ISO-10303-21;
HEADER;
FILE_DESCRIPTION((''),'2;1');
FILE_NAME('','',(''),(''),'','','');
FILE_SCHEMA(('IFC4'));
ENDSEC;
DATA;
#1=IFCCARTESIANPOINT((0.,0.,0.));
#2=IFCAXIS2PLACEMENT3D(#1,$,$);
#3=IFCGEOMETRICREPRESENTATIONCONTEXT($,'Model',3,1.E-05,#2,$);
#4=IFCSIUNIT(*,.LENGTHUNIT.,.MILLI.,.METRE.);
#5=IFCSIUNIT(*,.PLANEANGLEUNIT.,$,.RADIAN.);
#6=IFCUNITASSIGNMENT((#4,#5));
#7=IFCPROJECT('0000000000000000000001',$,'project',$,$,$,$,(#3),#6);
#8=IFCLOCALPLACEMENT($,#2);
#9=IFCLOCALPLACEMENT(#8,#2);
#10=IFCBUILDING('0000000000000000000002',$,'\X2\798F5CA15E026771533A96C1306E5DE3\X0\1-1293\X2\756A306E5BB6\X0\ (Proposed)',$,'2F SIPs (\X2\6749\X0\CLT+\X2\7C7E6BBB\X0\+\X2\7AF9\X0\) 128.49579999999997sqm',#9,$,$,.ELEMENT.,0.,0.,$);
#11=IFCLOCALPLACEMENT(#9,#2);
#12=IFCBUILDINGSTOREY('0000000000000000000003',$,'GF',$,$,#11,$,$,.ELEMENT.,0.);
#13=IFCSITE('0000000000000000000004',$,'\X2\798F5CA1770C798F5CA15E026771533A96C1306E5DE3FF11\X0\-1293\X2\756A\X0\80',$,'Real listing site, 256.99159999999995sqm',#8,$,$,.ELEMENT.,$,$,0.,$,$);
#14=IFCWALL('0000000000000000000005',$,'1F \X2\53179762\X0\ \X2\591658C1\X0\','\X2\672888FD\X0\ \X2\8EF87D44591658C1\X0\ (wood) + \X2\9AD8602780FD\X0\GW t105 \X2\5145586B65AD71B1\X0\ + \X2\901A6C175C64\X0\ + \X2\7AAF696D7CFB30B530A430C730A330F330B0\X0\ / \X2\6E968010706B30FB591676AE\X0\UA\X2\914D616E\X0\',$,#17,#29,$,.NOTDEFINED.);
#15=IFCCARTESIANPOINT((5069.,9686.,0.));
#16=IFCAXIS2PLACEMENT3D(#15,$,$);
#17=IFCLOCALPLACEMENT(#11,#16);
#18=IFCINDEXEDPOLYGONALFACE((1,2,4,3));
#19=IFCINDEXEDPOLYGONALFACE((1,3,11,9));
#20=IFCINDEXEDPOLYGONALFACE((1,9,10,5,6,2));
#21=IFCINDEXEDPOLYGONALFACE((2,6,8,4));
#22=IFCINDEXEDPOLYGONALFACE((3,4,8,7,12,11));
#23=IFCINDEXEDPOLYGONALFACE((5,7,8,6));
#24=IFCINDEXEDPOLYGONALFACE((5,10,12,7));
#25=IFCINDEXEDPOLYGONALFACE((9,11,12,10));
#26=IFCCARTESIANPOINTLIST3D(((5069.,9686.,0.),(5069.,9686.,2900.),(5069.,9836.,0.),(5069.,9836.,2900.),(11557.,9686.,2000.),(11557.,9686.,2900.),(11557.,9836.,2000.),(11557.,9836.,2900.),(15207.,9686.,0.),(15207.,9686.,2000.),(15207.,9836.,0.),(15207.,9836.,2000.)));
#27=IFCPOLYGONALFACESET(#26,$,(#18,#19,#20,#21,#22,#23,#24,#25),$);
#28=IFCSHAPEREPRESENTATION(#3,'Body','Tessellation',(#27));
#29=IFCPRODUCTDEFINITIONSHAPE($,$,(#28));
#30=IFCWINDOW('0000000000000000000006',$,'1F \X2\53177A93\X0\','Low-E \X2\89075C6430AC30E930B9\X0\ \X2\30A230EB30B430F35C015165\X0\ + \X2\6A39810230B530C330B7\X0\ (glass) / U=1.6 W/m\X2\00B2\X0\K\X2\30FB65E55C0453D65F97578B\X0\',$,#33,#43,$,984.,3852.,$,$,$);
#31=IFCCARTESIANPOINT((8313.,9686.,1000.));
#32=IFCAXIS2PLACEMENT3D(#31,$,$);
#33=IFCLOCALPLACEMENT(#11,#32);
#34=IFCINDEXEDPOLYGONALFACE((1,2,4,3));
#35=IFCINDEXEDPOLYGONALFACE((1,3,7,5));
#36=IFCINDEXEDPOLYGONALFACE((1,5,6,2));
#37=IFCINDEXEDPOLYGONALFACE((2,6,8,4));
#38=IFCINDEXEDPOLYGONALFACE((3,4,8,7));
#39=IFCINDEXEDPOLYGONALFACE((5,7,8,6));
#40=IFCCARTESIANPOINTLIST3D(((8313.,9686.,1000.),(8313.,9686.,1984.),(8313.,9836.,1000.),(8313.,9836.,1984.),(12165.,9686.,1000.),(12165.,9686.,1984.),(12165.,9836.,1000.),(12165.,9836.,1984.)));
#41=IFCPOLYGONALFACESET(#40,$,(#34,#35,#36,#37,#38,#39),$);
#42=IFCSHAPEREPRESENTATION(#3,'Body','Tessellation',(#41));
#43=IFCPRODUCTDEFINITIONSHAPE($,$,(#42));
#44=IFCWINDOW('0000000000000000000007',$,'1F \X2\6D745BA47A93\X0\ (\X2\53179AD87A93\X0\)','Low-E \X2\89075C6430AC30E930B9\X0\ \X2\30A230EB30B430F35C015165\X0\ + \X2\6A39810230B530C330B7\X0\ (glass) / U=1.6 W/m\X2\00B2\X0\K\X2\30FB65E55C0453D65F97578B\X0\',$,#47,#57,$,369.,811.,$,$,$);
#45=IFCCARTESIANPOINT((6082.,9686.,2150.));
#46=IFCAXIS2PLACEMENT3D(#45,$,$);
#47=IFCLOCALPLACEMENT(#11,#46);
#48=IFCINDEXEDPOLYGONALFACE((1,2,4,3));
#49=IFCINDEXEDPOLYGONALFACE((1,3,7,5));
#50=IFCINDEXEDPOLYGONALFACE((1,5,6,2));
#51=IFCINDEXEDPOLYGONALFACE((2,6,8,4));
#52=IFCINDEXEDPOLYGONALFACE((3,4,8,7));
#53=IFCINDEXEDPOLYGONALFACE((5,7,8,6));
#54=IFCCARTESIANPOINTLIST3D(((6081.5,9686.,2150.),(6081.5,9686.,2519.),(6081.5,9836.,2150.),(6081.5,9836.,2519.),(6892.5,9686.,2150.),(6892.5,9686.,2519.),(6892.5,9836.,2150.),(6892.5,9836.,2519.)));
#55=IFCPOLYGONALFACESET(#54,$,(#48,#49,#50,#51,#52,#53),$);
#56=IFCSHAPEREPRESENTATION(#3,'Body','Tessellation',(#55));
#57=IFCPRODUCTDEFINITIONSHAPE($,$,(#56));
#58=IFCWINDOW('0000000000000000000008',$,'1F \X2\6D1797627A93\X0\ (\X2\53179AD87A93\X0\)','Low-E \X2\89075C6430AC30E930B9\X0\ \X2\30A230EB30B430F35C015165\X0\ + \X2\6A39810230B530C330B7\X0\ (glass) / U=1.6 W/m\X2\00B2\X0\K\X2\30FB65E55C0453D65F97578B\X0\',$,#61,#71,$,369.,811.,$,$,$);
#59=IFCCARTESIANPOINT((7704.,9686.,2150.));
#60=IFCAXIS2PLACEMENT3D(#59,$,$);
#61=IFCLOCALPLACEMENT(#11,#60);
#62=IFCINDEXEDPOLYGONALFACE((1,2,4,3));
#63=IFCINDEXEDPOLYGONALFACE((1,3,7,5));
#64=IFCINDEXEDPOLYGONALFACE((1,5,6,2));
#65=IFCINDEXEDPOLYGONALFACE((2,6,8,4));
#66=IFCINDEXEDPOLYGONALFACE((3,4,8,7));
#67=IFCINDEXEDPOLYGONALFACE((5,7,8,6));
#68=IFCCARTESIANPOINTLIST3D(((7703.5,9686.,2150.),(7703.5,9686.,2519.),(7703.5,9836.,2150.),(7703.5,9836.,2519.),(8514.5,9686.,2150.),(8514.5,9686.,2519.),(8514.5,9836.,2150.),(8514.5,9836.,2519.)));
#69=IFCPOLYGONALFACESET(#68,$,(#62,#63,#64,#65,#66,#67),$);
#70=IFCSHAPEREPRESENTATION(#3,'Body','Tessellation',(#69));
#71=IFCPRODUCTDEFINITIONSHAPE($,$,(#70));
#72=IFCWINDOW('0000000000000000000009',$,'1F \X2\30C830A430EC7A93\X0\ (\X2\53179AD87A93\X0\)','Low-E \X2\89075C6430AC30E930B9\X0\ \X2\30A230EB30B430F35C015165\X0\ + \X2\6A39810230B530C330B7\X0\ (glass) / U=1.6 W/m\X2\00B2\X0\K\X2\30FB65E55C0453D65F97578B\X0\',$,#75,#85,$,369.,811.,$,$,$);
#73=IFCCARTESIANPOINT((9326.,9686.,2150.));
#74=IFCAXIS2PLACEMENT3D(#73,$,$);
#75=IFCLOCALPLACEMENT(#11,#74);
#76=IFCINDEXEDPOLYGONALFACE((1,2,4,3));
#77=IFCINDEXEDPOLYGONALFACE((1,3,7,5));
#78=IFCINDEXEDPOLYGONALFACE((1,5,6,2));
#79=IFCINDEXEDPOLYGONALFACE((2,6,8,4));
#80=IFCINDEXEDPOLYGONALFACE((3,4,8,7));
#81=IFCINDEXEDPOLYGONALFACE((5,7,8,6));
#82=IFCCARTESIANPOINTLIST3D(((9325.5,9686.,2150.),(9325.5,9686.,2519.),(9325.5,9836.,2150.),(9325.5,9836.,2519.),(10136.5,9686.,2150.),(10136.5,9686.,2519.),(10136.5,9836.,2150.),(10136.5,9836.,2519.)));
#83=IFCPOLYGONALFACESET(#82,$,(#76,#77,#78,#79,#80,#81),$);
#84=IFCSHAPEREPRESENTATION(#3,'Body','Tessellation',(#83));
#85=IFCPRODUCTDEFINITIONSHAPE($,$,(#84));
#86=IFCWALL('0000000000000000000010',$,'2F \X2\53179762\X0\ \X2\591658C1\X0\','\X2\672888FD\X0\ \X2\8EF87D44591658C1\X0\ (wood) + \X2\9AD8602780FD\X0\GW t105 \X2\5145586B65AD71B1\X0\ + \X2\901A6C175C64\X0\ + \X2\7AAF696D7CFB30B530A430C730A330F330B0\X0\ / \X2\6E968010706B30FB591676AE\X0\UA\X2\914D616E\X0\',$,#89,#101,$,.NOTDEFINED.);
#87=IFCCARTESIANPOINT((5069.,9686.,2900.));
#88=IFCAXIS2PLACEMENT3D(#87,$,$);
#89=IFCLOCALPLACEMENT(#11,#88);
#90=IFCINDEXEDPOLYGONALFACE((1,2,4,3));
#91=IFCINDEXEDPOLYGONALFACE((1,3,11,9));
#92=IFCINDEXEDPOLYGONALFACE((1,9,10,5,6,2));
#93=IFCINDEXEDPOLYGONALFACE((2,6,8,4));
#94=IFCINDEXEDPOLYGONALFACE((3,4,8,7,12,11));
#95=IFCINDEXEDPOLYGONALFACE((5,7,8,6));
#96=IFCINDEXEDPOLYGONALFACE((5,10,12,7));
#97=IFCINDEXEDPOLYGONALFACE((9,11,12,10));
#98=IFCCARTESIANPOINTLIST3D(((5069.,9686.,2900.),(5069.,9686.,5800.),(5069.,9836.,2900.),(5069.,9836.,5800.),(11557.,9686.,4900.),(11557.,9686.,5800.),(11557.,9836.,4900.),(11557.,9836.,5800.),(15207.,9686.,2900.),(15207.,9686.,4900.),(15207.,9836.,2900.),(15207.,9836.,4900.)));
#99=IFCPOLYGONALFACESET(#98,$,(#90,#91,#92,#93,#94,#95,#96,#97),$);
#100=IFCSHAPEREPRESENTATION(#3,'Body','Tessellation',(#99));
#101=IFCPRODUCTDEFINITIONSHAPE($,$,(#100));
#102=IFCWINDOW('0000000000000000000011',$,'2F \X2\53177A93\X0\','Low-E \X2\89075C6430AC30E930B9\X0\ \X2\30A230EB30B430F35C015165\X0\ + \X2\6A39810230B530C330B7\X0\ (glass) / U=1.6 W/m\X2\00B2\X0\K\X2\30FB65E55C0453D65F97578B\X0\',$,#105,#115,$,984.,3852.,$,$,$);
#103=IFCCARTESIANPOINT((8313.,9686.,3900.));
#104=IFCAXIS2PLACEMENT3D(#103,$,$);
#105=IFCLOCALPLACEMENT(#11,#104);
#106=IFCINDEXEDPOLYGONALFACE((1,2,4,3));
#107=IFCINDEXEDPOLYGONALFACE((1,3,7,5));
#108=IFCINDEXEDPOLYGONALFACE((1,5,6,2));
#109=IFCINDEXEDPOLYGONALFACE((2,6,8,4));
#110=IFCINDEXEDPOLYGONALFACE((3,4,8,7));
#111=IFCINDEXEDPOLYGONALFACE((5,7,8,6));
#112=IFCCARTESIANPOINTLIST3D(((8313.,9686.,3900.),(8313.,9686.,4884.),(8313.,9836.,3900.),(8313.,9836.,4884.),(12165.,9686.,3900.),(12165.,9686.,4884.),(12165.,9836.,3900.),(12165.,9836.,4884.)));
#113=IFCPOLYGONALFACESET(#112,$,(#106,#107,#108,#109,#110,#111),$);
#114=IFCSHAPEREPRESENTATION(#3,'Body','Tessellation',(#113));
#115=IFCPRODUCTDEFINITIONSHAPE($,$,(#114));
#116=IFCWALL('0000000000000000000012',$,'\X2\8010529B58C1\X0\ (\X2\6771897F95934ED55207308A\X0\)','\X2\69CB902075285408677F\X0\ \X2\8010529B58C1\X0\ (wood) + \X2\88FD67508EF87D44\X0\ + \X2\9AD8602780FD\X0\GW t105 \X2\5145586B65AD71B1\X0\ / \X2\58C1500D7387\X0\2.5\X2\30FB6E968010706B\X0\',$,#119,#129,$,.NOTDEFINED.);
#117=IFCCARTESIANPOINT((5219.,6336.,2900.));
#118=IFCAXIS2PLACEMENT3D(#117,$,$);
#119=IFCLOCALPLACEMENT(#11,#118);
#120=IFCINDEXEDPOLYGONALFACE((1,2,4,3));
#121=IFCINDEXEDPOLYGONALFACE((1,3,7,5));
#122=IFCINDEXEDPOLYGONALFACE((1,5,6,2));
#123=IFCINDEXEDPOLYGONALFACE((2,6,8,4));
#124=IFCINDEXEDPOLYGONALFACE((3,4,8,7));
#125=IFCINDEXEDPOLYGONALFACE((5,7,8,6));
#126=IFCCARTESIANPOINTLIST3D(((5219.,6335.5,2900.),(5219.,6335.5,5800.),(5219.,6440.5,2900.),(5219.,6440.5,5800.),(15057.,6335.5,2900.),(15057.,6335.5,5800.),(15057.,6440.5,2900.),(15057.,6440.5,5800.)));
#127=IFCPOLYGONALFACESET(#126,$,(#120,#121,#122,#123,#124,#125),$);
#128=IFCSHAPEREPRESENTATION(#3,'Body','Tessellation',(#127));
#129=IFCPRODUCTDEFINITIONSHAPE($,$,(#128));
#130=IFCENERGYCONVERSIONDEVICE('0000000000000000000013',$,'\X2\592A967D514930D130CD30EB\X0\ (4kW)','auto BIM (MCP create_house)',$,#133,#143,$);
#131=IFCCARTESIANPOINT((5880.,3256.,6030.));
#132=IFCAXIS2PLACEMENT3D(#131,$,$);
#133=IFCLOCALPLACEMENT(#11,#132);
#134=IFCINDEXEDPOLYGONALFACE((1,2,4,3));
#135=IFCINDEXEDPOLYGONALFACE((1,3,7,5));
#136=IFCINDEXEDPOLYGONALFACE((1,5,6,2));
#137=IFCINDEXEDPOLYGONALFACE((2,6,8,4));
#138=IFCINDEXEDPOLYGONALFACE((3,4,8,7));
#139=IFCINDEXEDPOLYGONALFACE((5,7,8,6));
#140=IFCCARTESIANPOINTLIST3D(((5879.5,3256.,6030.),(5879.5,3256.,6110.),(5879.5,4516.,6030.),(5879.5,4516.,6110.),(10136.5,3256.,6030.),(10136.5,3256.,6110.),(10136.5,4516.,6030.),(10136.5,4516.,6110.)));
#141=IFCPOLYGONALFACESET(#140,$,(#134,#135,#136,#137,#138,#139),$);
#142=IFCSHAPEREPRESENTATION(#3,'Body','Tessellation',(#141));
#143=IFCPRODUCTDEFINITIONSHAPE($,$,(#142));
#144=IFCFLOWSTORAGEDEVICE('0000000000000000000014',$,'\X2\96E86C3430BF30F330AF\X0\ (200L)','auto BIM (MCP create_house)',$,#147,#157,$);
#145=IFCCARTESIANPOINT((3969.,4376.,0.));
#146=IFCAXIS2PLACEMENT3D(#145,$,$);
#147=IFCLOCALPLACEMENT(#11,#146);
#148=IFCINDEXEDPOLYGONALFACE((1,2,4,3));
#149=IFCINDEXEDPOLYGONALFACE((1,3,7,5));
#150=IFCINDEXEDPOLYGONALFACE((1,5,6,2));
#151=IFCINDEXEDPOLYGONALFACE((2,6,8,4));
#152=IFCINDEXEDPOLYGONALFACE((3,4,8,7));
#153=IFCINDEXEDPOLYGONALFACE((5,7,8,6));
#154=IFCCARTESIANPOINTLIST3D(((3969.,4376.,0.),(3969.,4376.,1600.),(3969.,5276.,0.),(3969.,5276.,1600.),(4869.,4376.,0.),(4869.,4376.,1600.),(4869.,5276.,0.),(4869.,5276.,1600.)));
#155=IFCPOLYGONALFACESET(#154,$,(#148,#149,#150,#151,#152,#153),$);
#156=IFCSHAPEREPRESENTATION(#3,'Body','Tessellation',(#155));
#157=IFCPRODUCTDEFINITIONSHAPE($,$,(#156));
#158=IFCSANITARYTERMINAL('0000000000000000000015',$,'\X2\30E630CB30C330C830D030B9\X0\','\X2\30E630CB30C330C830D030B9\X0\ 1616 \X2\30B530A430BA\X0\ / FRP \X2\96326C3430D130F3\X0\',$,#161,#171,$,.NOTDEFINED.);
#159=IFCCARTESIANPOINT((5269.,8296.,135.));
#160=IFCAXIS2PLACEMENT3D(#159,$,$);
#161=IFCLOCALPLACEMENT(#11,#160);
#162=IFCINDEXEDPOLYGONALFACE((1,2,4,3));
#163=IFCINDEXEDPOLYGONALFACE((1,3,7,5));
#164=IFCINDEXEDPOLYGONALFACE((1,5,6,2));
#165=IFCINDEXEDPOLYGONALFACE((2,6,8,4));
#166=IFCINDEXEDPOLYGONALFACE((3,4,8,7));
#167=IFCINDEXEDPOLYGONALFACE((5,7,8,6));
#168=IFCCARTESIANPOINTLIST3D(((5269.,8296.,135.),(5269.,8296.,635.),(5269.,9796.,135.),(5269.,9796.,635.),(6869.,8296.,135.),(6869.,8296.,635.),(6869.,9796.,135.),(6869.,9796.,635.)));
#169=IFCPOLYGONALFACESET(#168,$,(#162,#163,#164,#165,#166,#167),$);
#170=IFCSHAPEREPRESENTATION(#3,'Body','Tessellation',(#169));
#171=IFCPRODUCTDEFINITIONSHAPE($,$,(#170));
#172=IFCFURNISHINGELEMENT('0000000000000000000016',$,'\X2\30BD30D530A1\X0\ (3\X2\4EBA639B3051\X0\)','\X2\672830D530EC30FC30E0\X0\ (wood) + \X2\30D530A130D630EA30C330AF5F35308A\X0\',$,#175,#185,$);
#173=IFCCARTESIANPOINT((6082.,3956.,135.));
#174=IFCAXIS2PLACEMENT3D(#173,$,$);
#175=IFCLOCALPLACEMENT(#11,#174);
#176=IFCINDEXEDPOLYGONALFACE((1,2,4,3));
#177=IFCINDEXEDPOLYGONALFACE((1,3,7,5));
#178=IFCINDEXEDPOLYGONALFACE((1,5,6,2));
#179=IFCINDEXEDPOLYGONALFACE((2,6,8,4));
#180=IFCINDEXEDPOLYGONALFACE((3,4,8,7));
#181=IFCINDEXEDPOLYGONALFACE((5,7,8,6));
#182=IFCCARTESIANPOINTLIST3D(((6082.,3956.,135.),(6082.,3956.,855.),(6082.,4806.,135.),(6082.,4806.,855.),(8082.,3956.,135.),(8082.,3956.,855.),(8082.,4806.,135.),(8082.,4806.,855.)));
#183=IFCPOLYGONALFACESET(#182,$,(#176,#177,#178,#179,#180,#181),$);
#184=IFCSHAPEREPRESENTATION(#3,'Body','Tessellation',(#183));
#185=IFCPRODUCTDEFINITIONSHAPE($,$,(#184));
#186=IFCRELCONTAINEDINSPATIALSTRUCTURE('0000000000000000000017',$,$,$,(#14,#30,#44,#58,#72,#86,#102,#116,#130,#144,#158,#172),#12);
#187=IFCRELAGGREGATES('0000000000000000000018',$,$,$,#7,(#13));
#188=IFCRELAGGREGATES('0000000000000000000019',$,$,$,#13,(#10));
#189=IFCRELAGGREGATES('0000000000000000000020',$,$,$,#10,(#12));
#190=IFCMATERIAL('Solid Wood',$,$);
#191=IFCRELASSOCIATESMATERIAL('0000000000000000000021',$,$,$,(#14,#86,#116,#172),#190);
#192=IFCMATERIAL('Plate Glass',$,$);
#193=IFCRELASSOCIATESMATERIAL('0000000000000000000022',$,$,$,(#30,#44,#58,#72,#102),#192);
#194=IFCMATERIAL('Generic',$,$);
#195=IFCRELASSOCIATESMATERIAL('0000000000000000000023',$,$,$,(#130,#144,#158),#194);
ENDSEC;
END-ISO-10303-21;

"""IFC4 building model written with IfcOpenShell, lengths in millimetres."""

from ifc_helpers import new_model, si_unit, frame, frame_2d, origin, place, context, project, spatial, rectangle, extrude, material, element, fill, save


model = new_model("IFC4")

# Units and contexts
model_context = context("Model", 3, precision=1e-05, world=origin())
ifc_project = project(units=[si_unit("LENGTHUNIT", "METRE", prefix="MILLI"), si_unit("PLANEANGLEUNIT", "RADIAN")], contexts=[model_context])

# Site, building, storey
site_placement = place(None, origin())
site = spatial("IfcSite", under=ifc_project, at=site_placement, Name="福岡県福岡市東区雁の巣１-1293番80", ObjectType="Real listing site, 256.99159999999995sqm", CompositionType="ELEMENT", RefElevation=0.0)
building_placement = place(site_placement, origin())
building = spatial("IfcBuilding", under=site, at=building_placement, Name="福岡市東区雁の巣1-1293番の家 (Proposed)", ObjectType="2F SIPs (杉CLT+籾殻+竹) 128.49579999999997sqm", CompositionType="ELEMENT", ElevationOfRefHeight=0.0, ElevationOfTerrain=0.0)
storey_placement = place(building_placement, origin())
storey = spatial("IfcBuildingStorey", under=building, at=storey_placement, Name="GF", CompositionType="ELEMENT", Elevation=0.0)

# Wall, openings, windows
ifc_material_1 = material(Name="Solid Wood")
wall_1_placement = place(storey_placement, frame((5069.0, 9686.0, 0.0)))
wall_1 = element("IfcWall", 1, at=wall_1_placement, inside=storey, material=ifc_material_1, Name="1F 北面 外壁", Description="木製 軸組外壁 (wood) + 高性能GW t105 充填断熱 + 通気層 + 窯業系サイディング / 準耐火・外皮UA配慮", PredefinedType="NOTDEFINED", context=model_context, shape_type="SweptSolid", body=[
    extrude(rectangle(XDim=10138.0, YDim=150.0, at=frame_2d((5069.0, 75.0))), frame((5069.0, 9686.0, 0.0)), (0.0, 0.0, 1.0), 2900.0),
])
opening_1_placement = place(storey_placement, frame((8313.0, 9686.0, 1000.0)))
opening_1 = element("IfcOpeningElement", 2, at=opening_1_placement, cuts=wall_1, PredefinedType="NOTDEFINED", context=model_context, shape_type="SweptSolid", body=[
    extrude(rectangle(XDim=3852.0, YDim=150.0, at=frame_2d((1926.0, 75.0))), frame((8313.0, 9686.0, 1000.0)), (0.0, 0.0, 1.0), 984.0),
])
opening_2_placement = place(storey_placement, frame((6082.0, 9686.0, 2150.0)))
opening_2 = element("IfcOpeningElement", 3, at=opening_2_placement, cuts=wall_1, PredefinedType="NOTDEFINED", context=model_context, shape_type="SweptSolid", body=[
    extrude(rectangle(XDim=811.0, YDim=150.0, at=frame_2d((405.0, 75.0))), frame((6082.0, 9686.0, 2150.0)), (0.0, 0.0, 1.0), 369.0),
])
opening_3_placement = place(storey_placement, frame((7704.0, 9686.0, 2150.0)))
opening_3 = element("IfcOpeningElement", 4, at=opening_3_placement, cuts=wall_1, PredefinedType="NOTDEFINED", context=model_context, shape_type="SweptSolid", body=[
    extrude(rectangle(XDim=811.0, YDim=150.0, at=frame_2d((405.0, 75.0))), frame((7704.0, 9686.0, 2150.0)), (0.0, 0.0, 1.0), 369.0),
])
opening_4_placement = place(storey_placement, frame((9326.0, 9686.0, 2150.0)))
opening_4 = element("IfcOpeningElement", 5, at=opening_4_placement, cuts=wall_1, PredefinedType="NOTDEFINED", context=model_context, shape_type="SweptSolid", body=[
    extrude(rectangle(XDim=811.0, YDim=150.0, at=frame_2d((405.0, 75.0))), frame((9326.0, 9686.0, 2150.0)), (0.0, 0.0, 1.0), 369.0),
])
ifc_material_2 = material(Name="Plate Glass")
window_1_placement = place(storey_placement, frame((8313.0, 9686.0, 1000.0)))
window_1 = element("IfcWindow", 6, at=window_1_placement, inside=storey, material=ifc_material_2, Name="1F 北窓", Description="Low-E 複層ガラス アルゴン封入 + 樹脂サッシ (glass) / U=1.6 W/m²K・日射取得型", OverallHeight=984.0, OverallWidth=3852.0, context=model_context, shape_type="SweptSolid", body=[
    extrude(rectangle(XDim=3852.0, YDim=150.0, at=frame_2d((1926.0, 75.0))), frame((8313.0, 9686.0, 1000.0)), (0.0, 0.0, 1.0), 984.0),
])
fill(opening_1, window_1)
window_2_placement = place(storey_placement, frame((6082.0, 9686.0, 2150.0)))
window_2 = element("IfcWindow", 7, at=window_2_placement, inside=storey, material=ifc_material_2, Name="1F 浴室窓 (北高窓)", Description="Low-E 複層ガラス アルゴン封入 + 樹脂サッシ (glass) / U=1.6 W/m²K・日射取得型", OverallHeight=369.0, OverallWidth=811.0, context=model_context, shape_type="SweptSolid", body=[
    extrude(rectangle(XDim=811.0, YDim=150.0, at=frame_2d((405.0, 75.0))), frame((6082.0, 9686.0, 2150.0)), (0.0, 0.0, 1.0), 369.0),
])
fill(opening_2, window_2)
window_3_placement = place(storey_placement, frame((7704.0, 9686.0, 2150.0)))
window_3 = element("IfcWindow", 8, at=window_3_placement, inside=storey, material=ifc_material_2, Name="1F 洗面窓 (北高窓)", Description="Low-E 複層ガラス アルゴン封入 + 樹脂サッシ (glass) / U=1.6 W/m²K・日射取得型", OverallHeight=369.0, OverallWidth=811.0, context=model_context, shape_type="SweptSolid", body=[
    extrude(rectangle(XDim=811.0, YDim=150.0, at=frame_2d((405.0, 75.0))), frame((7704.0, 9686.0, 2150.0)), (0.0, 0.0, 1.0), 369.0),
])
fill(opening_3, window_3)
window_4_placement = place(storey_placement, frame((9326.0, 9686.0, 2150.0)))
window_4 = element("IfcWindow", 9, at=window_4_placement, inside=storey, material=ifc_material_2, Name="1F トイレ窓 (北高窓)", Description="Low-E 複層ガラス アルゴン封入 + 樹脂サッシ (glass) / U=1.6 W/m²K・日射取得型", OverallHeight=369.0, OverallWidth=811.0, context=model_context, shape_type="SweptSolid", body=[
    extrude(rectangle(XDim=811.0, YDim=150.0, at=frame_2d((405.0, 75.0))), frame((9326.0, 9686.0, 2150.0)), (0.0, 0.0, 1.0), 369.0),
])
fill(opening_4, window_4)

# Wall, opening, window
wall_2_placement = place(storey_placement, frame((5069.0, 9686.0, 2900.0)))
wall_2 = element("IfcWall", 10, at=wall_2_placement, inside=storey, material=ifc_material_1, Name="2F 北面 外壁", Description="木製 軸組外壁 (wood) + 高性能GW t105 充填断熱 + 通気層 + 窯業系サイディング / 準耐火・外皮UA配慮", PredefinedType="NOTDEFINED", context=model_context, shape_type="SweptSolid", body=[
    extrude(rectangle(XDim=10138.0, YDim=150.0, at=frame_2d((5069.0, 75.0))), frame((5069.0, 9686.0, 2900.0)), (0.0, 0.0, 1.0), 2900.0),
])
opening_5_placement = place(storey_placement, frame((8313.0, 9686.0, 3900.0)))
opening_5 = element("IfcOpeningElement", 11, at=opening_5_placement, cuts=wall_2, PredefinedType="NOTDEFINED", context=model_context, shape_type="SweptSolid", body=[
    extrude(rectangle(XDim=3852.0, YDim=150.0, at=frame_2d((1926.0, 75.0))), frame((8313.0, 9686.0, 3900.0)), (0.0, 0.0, 1.0), 984.0),
])
window_5_placement = place(storey_placement, frame((8313.0, 9686.0, 3900.0)))
window_5 = element("IfcWindow", 12, at=window_5_placement, inside=storey, material=ifc_material_2, Name="2F 北窓", Description="Low-E 複層ガラス アルゴン封入 + 樹脂サッシ (glass) / U=1.6 W/m²K・日射取得型", OverallHeight=984.0, OverallWidth=3852.0, context=model_context, shape_type="SweptSolid", body=[
    extrude(rectangle(XDim=3852.0, YDim=150.0, at=frame_2d((1926.0, 75.0))), frame((8313.0, 9686.0, 3900.0)), (0.0, 0.0, 1.0), 984.0),
])
fill(opening_5, window_5)

# Wall
wall_3_placement = place(storey_placement, frame((5219.0, 6336.0, 2900.0)))
element("IfcWall", 13, at=wall_3_placement, inside=storey, material=ifc_material_1, Name="耐力壁 (東西間仕切り)", Description="構造用合板 耐力壁 (wood) + 製材軸組 + 高性能GW t105 充填断熱 / 壁倍率2.5・準耐火", PredefinedType="NOTDEFINED", context=model_context, shape_type="SweptSolid", body=[
    extrude(rectangle(XDim=9838.0, YDim=105.0, at=frame_2d((4919.0, 52.0))), frame((5219.0, 6336.0, 2900.0)), (0.0, 0.0, 1.0), 2900.0),
])

# Energy conversion device
ifc_material_3 = material(Name="Generic")
energy_conversion_device_placement = place(storey_placement, frame((5880.0, 3256.0, 6030.0)))
element("IfcEnergyConversionDevice", 14, at=energy_conversion_device_placement, inside=storey, material=ifc_material_3, Name="太陽光パネル (4kW)", Description="auto BIM (MCP create_house)", context=model_context, shape_type="SweptSolid", body=[
    extrude(rectangle(XDim=4257.0, YDim=1260.0, at=frame_2d((2128.0, 630.0))), frame((5880.0, 3256.0, 6030.0)), (0.0, 0.0, 1.0), 80.0),
])

# Flow storage device
flow_storage_device_placement = place(storey_placement, frame((3969.0, 4376.0, 0.0)))
element("IfcFlowStorageDevice", 15, at=flow_storage_device_placement, inside=storey, material=ifc_material_3, Name="雨水タンク (200L)", Description="auto BIM (MCP create_house)", context=model_context, shape_type="SweptSolid", body=[
    extrude(rectangle(XDim=900.0, YDim=900.0, at=frame_2d((450.0, 450.0))), frame((3969.0, 4376.0, 0.0)), (0.0, 0.0, 1.0), 1600.0),
])

# Sanitary terminal
sanitary_terminal_placement = place(storey_placement, frame((5269.0, 8296.0, 135.0)))
element("IfcSanitaryTerminal", 16, at=sanitary_terminal_placement, inside=storey, material=ifc_material_3, Name="ユニットバス", Description="ユニットバス 1616 サイズ / FRP 防水パン", PredefinedType="NOTDEFINED", context=model_context, shape_type="SweptSolid", body=[
    extrude(rectangle(XDim=1600.0, YDim=1500.0, at=frame_2d((800.0, 750.0))), frame((5269.0, 8296.0, 135.0)), (0.0, 0.0, 1.0), 500.0),
])

# Furnishing element
furnishing_1_placement = place(storey_placement, frame((6082.0, 3956.0, 135.0)))
element("IfcFurnishingElement", 17, at=furnishing_1_placement, inside=storey, material=ifc_material_1, Name="ソファ (3人掛け)", Description="木フレーム (wood) + ファブリック張り", context=model_context, shape_type="SweptSolid", body=[
    extrude(rectangle(XDim=2000.0, YDim=850.0, at=frame_2d((1000.0, 425.0))), frame((6082.0, 3956.0, 135.0)), (0.0, 0.0, 1.0), 720.0),
])

save(model, "model.ifc")
